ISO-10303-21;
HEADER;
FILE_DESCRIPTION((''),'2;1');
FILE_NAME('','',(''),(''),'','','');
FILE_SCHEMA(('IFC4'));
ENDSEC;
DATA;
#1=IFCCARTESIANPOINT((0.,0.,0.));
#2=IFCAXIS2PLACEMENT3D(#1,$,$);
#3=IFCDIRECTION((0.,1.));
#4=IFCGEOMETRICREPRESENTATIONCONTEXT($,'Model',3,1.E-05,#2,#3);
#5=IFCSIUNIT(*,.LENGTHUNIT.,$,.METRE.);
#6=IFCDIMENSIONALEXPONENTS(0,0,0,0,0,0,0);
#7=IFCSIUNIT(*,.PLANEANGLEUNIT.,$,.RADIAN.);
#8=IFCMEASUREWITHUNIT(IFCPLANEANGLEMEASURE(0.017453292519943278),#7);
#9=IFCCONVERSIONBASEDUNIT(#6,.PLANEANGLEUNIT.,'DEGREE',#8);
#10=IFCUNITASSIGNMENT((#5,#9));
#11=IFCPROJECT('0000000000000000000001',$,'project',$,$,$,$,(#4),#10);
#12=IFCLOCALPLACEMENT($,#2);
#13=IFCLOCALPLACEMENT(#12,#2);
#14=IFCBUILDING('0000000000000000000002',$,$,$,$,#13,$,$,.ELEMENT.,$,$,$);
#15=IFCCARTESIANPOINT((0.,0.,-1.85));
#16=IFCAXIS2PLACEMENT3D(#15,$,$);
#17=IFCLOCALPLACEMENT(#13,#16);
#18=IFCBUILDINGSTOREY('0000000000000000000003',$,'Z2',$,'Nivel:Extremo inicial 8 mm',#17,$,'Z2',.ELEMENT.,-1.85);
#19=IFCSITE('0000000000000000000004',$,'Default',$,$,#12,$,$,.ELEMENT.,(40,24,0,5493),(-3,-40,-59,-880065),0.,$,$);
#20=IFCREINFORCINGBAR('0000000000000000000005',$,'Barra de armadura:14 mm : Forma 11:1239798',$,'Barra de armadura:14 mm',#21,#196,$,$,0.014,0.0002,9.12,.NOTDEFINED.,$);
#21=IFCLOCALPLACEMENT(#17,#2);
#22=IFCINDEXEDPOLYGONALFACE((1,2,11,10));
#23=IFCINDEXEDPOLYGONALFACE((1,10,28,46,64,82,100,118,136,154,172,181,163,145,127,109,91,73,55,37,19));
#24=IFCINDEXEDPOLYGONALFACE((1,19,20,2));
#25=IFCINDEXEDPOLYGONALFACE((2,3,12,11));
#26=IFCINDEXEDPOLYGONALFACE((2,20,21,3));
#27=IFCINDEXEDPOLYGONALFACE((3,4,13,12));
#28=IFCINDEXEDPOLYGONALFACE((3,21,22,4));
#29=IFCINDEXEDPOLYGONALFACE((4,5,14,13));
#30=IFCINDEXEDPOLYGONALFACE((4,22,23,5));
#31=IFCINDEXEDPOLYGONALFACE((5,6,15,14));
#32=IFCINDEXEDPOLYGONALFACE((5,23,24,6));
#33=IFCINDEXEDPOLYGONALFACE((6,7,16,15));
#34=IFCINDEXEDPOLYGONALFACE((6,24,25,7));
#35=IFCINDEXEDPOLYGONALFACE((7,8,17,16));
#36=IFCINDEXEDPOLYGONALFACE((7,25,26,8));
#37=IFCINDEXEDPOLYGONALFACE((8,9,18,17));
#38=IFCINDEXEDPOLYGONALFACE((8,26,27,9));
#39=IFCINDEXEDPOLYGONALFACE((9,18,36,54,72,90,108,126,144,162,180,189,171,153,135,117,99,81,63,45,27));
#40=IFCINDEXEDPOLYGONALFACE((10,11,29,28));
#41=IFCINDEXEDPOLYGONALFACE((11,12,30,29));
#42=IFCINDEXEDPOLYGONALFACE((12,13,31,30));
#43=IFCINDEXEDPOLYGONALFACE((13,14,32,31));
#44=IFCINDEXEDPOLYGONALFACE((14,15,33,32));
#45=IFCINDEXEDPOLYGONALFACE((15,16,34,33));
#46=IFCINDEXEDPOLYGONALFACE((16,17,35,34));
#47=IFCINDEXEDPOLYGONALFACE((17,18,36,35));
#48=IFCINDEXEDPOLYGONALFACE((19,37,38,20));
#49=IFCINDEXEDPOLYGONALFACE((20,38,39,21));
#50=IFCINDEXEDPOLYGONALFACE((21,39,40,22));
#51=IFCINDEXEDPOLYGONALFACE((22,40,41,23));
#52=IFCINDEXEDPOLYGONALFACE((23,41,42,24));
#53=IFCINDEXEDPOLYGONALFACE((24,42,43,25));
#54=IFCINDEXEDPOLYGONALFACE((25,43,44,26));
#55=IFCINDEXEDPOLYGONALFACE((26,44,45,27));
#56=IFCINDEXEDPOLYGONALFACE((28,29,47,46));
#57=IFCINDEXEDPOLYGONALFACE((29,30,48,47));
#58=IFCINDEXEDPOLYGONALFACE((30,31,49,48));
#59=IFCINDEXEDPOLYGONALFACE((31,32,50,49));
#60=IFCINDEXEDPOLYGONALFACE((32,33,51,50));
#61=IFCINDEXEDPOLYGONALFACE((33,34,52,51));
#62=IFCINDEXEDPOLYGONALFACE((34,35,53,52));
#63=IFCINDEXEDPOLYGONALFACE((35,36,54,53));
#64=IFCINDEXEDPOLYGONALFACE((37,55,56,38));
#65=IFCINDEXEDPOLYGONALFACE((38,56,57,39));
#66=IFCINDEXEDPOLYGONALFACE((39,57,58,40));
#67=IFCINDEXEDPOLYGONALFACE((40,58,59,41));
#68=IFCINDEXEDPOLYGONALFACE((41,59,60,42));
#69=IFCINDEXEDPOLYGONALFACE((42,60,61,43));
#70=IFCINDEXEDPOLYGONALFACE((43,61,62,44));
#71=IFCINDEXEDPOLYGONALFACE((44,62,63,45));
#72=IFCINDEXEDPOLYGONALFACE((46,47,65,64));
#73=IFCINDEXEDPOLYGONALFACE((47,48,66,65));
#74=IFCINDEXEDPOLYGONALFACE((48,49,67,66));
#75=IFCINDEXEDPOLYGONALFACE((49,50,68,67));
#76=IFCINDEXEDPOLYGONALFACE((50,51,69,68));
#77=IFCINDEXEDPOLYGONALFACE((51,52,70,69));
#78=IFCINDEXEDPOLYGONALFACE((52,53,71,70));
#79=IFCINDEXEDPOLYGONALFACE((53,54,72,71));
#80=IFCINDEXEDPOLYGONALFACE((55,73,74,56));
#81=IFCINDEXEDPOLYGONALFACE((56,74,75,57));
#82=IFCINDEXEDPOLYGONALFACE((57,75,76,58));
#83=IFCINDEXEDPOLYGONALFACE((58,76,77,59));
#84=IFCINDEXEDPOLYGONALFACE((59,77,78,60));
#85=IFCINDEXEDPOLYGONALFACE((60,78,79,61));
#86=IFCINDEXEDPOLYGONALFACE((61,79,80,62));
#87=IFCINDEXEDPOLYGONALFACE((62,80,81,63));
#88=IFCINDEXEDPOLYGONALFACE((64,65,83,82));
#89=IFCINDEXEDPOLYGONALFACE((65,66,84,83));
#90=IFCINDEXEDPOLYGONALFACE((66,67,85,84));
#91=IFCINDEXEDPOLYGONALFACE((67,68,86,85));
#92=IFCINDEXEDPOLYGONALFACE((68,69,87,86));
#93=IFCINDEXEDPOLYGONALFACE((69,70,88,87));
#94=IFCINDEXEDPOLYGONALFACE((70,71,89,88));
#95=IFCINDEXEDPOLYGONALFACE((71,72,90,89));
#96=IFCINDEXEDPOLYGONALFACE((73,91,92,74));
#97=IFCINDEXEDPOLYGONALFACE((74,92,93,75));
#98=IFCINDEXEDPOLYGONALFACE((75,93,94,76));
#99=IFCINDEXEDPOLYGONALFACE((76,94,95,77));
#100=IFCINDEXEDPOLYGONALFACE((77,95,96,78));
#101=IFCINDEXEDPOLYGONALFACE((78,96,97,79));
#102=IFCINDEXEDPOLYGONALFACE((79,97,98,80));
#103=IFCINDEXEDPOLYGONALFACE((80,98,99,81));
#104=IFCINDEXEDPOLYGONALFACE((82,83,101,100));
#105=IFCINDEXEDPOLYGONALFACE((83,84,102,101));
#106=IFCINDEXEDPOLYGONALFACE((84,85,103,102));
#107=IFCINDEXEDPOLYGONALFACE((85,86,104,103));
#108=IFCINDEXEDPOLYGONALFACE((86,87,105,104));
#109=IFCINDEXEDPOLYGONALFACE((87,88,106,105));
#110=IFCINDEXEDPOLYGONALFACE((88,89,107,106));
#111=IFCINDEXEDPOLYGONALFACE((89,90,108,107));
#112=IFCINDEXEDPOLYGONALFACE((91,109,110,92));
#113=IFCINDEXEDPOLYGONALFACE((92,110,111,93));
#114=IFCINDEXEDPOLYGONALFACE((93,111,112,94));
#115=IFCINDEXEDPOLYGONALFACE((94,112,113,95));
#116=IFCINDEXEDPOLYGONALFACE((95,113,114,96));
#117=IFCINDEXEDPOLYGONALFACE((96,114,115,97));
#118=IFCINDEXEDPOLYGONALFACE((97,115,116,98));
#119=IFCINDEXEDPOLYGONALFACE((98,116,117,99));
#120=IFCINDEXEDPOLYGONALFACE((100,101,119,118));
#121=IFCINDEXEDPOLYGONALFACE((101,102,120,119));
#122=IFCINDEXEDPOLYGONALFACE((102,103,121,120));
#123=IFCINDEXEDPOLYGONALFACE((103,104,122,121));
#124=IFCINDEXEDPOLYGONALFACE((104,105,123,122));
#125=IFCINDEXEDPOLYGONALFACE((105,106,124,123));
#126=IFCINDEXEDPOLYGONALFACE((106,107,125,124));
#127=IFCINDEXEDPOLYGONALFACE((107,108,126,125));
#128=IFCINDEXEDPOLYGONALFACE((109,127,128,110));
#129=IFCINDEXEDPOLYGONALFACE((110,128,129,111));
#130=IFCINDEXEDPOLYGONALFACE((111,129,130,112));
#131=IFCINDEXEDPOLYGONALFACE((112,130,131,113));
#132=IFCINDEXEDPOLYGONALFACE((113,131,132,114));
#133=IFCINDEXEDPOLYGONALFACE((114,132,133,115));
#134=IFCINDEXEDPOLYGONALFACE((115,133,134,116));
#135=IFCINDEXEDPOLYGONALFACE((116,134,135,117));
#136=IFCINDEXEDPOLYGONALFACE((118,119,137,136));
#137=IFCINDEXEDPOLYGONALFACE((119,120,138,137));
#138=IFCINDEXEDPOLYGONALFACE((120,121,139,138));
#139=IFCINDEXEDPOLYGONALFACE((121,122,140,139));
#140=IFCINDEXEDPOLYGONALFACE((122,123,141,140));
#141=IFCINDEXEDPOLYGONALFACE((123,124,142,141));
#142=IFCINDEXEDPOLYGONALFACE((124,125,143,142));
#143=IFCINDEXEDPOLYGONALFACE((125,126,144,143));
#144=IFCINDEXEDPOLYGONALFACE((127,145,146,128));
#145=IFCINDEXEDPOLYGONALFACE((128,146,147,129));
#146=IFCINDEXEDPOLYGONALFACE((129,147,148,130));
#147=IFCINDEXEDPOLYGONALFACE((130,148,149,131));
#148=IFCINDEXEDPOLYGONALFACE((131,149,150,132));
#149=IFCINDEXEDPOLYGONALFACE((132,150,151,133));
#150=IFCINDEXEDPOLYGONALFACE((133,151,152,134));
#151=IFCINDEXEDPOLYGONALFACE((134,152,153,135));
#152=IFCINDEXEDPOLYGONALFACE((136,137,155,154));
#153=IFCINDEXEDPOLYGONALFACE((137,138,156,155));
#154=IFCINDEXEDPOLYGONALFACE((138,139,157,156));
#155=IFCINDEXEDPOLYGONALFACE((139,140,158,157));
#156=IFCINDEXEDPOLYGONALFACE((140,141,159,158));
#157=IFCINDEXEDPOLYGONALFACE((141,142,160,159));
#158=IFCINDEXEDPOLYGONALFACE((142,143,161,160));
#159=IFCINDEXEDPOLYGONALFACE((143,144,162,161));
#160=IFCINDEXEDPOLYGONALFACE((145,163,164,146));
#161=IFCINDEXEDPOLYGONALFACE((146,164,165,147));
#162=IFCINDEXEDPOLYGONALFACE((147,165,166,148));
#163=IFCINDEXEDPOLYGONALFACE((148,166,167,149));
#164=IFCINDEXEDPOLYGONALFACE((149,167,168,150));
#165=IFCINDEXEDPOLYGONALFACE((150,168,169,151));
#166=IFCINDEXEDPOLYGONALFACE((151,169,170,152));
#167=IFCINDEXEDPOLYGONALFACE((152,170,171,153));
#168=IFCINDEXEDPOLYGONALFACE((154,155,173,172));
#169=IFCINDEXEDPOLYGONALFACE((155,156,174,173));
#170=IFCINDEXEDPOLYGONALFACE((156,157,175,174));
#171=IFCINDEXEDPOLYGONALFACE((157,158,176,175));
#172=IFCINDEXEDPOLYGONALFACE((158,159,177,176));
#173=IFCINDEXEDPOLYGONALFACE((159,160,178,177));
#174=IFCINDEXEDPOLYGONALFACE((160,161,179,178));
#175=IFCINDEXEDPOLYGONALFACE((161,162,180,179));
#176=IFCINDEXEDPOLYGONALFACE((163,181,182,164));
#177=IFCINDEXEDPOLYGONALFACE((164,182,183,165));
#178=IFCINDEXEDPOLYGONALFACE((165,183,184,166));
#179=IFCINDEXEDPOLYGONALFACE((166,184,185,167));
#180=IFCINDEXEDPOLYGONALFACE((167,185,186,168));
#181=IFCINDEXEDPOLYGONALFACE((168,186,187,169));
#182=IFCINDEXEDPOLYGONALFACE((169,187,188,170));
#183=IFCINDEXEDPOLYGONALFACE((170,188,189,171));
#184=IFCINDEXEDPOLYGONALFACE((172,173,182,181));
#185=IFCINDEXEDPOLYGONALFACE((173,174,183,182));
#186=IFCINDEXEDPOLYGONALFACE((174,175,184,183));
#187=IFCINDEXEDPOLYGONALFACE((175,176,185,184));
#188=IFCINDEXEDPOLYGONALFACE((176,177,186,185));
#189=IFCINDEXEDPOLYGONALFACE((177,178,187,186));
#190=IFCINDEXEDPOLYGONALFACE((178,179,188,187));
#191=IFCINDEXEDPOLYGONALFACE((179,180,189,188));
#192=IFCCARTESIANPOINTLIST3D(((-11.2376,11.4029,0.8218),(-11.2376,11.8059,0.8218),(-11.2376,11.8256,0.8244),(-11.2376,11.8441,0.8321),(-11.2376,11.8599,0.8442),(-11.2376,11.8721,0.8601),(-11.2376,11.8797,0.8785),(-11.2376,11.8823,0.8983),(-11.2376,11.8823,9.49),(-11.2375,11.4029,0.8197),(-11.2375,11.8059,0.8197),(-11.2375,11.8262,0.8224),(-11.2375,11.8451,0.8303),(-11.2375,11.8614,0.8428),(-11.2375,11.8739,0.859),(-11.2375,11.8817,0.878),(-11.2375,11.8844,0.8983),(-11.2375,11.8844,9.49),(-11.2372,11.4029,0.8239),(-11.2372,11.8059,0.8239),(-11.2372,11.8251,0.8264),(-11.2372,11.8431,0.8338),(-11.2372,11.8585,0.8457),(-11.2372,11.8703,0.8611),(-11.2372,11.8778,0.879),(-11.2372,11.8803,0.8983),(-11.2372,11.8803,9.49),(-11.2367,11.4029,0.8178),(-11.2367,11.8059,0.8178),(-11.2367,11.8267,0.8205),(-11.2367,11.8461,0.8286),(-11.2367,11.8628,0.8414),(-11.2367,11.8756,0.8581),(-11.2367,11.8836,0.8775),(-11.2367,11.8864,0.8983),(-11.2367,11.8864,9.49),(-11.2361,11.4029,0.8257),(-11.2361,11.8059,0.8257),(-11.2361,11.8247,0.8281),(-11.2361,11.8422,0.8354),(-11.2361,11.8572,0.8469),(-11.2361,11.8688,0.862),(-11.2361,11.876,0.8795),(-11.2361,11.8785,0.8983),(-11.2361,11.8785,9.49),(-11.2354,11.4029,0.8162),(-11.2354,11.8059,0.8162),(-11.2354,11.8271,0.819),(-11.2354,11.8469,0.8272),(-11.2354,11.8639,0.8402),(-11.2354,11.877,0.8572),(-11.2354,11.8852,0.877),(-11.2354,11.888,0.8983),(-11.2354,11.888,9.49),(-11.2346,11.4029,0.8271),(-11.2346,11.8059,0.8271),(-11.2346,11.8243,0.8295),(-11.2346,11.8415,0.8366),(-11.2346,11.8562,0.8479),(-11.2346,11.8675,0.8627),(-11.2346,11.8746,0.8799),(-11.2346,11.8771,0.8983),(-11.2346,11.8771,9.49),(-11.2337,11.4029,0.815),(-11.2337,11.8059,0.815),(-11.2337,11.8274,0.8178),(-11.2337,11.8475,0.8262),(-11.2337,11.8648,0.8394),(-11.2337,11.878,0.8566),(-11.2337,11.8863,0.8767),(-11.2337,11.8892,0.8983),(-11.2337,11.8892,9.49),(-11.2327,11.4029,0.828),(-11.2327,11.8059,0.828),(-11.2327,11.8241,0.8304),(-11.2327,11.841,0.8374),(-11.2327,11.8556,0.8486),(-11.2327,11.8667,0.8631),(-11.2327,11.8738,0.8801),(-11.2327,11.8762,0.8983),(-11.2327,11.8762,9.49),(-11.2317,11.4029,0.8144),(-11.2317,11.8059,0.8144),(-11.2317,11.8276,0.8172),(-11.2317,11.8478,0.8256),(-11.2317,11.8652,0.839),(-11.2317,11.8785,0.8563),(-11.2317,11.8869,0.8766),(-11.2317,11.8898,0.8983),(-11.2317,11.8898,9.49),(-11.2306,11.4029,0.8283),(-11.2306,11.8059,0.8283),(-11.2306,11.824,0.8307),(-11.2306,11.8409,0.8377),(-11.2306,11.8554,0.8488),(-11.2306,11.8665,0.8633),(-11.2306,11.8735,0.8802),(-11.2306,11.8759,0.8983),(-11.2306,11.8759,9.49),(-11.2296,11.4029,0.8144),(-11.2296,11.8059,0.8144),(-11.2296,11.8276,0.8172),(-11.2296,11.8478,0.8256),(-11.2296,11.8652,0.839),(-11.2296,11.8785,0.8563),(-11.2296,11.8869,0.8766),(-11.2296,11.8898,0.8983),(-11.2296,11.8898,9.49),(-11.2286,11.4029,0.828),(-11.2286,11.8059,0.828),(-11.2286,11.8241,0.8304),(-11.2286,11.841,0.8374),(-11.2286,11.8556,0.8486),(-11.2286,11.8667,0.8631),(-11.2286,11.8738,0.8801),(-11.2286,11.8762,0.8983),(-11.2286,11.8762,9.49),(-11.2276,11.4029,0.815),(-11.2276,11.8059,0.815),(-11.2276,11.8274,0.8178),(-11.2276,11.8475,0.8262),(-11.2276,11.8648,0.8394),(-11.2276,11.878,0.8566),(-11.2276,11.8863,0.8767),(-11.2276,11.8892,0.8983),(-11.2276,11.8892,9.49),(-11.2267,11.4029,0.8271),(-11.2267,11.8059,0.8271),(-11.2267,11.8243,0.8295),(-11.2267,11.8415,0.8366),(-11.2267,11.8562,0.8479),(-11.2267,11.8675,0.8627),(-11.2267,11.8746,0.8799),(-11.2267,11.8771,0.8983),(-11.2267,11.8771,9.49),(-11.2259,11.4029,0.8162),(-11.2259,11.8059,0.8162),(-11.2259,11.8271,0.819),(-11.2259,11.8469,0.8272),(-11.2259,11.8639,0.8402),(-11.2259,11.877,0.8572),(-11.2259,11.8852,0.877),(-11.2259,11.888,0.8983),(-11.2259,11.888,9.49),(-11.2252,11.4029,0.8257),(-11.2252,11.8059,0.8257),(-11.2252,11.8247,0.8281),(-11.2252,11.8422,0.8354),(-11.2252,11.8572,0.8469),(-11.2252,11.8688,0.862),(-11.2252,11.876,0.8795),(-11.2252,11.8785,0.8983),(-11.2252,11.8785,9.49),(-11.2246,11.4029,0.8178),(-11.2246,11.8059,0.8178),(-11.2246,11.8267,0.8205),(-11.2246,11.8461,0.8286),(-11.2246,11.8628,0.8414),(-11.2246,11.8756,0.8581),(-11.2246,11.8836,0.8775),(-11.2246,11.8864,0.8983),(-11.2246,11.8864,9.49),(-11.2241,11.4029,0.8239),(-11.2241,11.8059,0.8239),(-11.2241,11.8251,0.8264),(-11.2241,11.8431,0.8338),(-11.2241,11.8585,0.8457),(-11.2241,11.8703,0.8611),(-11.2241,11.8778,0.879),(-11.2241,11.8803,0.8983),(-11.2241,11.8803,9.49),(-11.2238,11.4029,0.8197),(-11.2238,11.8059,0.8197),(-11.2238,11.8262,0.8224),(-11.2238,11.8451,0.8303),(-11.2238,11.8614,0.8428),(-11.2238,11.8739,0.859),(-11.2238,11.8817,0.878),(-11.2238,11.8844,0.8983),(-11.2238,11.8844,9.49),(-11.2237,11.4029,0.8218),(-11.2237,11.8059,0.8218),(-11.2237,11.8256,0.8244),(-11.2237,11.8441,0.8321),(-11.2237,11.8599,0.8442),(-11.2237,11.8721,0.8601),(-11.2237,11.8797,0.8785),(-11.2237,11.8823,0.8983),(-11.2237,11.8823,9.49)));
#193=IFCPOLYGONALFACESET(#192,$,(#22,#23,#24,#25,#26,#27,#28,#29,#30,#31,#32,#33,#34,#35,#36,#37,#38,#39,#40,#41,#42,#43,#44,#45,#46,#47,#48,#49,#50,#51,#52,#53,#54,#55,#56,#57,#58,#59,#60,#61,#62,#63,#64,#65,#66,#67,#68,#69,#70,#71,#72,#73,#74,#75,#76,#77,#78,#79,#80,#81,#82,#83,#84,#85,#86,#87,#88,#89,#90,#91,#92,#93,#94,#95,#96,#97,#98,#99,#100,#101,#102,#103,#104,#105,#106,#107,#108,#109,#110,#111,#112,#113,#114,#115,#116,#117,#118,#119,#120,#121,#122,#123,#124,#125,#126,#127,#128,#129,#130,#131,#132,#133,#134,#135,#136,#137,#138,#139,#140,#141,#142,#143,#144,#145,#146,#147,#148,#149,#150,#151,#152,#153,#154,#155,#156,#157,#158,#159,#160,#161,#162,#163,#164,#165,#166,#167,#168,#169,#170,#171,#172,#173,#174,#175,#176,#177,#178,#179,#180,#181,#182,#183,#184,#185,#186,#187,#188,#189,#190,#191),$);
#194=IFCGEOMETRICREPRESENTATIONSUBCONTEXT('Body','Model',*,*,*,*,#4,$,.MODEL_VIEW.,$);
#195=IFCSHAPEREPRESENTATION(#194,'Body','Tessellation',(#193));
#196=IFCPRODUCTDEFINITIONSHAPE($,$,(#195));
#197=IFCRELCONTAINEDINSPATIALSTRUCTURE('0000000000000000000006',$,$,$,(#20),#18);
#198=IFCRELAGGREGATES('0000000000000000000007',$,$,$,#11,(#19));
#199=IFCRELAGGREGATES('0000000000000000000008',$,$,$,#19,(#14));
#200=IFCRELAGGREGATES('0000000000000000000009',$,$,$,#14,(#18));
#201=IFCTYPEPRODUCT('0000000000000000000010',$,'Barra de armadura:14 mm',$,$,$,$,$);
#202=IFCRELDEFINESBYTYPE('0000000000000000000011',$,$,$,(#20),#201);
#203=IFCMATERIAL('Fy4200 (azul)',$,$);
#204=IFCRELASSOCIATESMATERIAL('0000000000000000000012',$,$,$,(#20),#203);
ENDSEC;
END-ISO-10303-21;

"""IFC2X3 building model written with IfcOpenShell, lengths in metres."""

from ifc_helpers import new_model, entity, si_unit, converted_unit, direction, frame, origin, place, context, subcontext, project, spatial, material, type_object, element, save


model = new_model("IFC2X3")

# Units and contexts
model_context = context("Model", 3, precision=1e-05, world=origin(), true_north=direction((0.0, 1.0)))
body_context = subcontext(model_context, "Body", "Model", "MODEL_VIEW")
ifc_project = project(units=[si_unit("LENGTHUNIT", "METRE"), converted_unit("PLANEANGLEUNIT", "DEGREE", entity("IfcPlaneAngleMeasure", 0.017453292519943278), si_unit("PLANEANGLEUNIT", "RADIAN"), dimensions=[0, 0, 0, 0, 0, 0, 0])], contexts=[model_context])

# Site, building, storey
site_placement = place(None, origin())
site = spatial("IfcSite", under=ifc_project, at=site_placement, Name="Default", CompositionType="ELEMENT", RefLatitude=(40, 24, 0, 5493), RefLongitude=(-3, -40, -59, -880065), RefElevation=0.0)
building_placement = place(site_placement, origin())
building = spatial("IfcBuilding", under=site, at=building_placement, CompositionType="ELEMENT")
storey_placement = place(building_placement, frame((0.0, 0.0, -1.85)))
storey = spatial("IfcBuildingStorey", under=building, at=storey_placement, Name="Z2", ObjectType="Nivel:Extremo inicial 8 mm", LongName="Z2", CompositionType="ELEMENT", Elevation=-1.85)

# Reinforcing bar
ifc_material_1 = material(Name="Fy4200 (azul)")
type_product_1 = type_object("IfcTypeProduct", Name="Barra de armadura:14 mm")
reinforcing_bar_1_placement = place(storey_placement, origin())
element("IfcReinforcingBar", 1, at=reinforcing_bar_1_placement, inside=storey, type_object=type_product_1, material=ifc_material_1, Name="Barra de armadura:14 mm : Forma 11:1239798", ObjectType="Barra de armadura:14 mm", BarLength=9.12, BarRole="NOTDEFINED", CrossSectionArea=0.0002, NominalDiameter=0.014, context=body_context, shape_type="AdvancedSweptSolid", body=[
    entity("IfcSweptDiskSolid", entity("IfcCompositeCurve", [entity("IfcCompositeCurveSegment", "CONTINUOUS", True, entity("IfcPolyline", [entity("IfcCartesianPoint", [-11.2306, 11.8829, 9.49]), entity("IfcCartesianPoint", [-11.2306, 11.8829, 0.8983])])), entity("IfcCompositeCurveSegment", "CONTINUOUS", True, entity("IfcTrimmedCurve", entity("IfcCircle", entity("IfcAxis2Placement3D", entity("IfcCartesianPoint", [-11.2306, 11.8059, 0.8983]), entity("IfcDirection", [-1.0, 0.0, 0.0]), entity("IfcDirection", [0.0, 0.0, -1.0])), 0.077), [entity("IfcParameterValue", 270.0)], [entity("IfcParameterValue", 360.0)], True, "PARAMETER")), entity("IfcCompositeCurveSegment", "CONTINUOUS", True, entity("IfcPolyline", [entity("IfcCartesianPoint", [-11.2306, 11.8059, 0.8213]), entity("IfcCartesianPoint", [-11.2306, 11.4029, 0.8213])]))], False), 0.007, None, 0.0, 92.0),
])

save(model, "model.ifc")
